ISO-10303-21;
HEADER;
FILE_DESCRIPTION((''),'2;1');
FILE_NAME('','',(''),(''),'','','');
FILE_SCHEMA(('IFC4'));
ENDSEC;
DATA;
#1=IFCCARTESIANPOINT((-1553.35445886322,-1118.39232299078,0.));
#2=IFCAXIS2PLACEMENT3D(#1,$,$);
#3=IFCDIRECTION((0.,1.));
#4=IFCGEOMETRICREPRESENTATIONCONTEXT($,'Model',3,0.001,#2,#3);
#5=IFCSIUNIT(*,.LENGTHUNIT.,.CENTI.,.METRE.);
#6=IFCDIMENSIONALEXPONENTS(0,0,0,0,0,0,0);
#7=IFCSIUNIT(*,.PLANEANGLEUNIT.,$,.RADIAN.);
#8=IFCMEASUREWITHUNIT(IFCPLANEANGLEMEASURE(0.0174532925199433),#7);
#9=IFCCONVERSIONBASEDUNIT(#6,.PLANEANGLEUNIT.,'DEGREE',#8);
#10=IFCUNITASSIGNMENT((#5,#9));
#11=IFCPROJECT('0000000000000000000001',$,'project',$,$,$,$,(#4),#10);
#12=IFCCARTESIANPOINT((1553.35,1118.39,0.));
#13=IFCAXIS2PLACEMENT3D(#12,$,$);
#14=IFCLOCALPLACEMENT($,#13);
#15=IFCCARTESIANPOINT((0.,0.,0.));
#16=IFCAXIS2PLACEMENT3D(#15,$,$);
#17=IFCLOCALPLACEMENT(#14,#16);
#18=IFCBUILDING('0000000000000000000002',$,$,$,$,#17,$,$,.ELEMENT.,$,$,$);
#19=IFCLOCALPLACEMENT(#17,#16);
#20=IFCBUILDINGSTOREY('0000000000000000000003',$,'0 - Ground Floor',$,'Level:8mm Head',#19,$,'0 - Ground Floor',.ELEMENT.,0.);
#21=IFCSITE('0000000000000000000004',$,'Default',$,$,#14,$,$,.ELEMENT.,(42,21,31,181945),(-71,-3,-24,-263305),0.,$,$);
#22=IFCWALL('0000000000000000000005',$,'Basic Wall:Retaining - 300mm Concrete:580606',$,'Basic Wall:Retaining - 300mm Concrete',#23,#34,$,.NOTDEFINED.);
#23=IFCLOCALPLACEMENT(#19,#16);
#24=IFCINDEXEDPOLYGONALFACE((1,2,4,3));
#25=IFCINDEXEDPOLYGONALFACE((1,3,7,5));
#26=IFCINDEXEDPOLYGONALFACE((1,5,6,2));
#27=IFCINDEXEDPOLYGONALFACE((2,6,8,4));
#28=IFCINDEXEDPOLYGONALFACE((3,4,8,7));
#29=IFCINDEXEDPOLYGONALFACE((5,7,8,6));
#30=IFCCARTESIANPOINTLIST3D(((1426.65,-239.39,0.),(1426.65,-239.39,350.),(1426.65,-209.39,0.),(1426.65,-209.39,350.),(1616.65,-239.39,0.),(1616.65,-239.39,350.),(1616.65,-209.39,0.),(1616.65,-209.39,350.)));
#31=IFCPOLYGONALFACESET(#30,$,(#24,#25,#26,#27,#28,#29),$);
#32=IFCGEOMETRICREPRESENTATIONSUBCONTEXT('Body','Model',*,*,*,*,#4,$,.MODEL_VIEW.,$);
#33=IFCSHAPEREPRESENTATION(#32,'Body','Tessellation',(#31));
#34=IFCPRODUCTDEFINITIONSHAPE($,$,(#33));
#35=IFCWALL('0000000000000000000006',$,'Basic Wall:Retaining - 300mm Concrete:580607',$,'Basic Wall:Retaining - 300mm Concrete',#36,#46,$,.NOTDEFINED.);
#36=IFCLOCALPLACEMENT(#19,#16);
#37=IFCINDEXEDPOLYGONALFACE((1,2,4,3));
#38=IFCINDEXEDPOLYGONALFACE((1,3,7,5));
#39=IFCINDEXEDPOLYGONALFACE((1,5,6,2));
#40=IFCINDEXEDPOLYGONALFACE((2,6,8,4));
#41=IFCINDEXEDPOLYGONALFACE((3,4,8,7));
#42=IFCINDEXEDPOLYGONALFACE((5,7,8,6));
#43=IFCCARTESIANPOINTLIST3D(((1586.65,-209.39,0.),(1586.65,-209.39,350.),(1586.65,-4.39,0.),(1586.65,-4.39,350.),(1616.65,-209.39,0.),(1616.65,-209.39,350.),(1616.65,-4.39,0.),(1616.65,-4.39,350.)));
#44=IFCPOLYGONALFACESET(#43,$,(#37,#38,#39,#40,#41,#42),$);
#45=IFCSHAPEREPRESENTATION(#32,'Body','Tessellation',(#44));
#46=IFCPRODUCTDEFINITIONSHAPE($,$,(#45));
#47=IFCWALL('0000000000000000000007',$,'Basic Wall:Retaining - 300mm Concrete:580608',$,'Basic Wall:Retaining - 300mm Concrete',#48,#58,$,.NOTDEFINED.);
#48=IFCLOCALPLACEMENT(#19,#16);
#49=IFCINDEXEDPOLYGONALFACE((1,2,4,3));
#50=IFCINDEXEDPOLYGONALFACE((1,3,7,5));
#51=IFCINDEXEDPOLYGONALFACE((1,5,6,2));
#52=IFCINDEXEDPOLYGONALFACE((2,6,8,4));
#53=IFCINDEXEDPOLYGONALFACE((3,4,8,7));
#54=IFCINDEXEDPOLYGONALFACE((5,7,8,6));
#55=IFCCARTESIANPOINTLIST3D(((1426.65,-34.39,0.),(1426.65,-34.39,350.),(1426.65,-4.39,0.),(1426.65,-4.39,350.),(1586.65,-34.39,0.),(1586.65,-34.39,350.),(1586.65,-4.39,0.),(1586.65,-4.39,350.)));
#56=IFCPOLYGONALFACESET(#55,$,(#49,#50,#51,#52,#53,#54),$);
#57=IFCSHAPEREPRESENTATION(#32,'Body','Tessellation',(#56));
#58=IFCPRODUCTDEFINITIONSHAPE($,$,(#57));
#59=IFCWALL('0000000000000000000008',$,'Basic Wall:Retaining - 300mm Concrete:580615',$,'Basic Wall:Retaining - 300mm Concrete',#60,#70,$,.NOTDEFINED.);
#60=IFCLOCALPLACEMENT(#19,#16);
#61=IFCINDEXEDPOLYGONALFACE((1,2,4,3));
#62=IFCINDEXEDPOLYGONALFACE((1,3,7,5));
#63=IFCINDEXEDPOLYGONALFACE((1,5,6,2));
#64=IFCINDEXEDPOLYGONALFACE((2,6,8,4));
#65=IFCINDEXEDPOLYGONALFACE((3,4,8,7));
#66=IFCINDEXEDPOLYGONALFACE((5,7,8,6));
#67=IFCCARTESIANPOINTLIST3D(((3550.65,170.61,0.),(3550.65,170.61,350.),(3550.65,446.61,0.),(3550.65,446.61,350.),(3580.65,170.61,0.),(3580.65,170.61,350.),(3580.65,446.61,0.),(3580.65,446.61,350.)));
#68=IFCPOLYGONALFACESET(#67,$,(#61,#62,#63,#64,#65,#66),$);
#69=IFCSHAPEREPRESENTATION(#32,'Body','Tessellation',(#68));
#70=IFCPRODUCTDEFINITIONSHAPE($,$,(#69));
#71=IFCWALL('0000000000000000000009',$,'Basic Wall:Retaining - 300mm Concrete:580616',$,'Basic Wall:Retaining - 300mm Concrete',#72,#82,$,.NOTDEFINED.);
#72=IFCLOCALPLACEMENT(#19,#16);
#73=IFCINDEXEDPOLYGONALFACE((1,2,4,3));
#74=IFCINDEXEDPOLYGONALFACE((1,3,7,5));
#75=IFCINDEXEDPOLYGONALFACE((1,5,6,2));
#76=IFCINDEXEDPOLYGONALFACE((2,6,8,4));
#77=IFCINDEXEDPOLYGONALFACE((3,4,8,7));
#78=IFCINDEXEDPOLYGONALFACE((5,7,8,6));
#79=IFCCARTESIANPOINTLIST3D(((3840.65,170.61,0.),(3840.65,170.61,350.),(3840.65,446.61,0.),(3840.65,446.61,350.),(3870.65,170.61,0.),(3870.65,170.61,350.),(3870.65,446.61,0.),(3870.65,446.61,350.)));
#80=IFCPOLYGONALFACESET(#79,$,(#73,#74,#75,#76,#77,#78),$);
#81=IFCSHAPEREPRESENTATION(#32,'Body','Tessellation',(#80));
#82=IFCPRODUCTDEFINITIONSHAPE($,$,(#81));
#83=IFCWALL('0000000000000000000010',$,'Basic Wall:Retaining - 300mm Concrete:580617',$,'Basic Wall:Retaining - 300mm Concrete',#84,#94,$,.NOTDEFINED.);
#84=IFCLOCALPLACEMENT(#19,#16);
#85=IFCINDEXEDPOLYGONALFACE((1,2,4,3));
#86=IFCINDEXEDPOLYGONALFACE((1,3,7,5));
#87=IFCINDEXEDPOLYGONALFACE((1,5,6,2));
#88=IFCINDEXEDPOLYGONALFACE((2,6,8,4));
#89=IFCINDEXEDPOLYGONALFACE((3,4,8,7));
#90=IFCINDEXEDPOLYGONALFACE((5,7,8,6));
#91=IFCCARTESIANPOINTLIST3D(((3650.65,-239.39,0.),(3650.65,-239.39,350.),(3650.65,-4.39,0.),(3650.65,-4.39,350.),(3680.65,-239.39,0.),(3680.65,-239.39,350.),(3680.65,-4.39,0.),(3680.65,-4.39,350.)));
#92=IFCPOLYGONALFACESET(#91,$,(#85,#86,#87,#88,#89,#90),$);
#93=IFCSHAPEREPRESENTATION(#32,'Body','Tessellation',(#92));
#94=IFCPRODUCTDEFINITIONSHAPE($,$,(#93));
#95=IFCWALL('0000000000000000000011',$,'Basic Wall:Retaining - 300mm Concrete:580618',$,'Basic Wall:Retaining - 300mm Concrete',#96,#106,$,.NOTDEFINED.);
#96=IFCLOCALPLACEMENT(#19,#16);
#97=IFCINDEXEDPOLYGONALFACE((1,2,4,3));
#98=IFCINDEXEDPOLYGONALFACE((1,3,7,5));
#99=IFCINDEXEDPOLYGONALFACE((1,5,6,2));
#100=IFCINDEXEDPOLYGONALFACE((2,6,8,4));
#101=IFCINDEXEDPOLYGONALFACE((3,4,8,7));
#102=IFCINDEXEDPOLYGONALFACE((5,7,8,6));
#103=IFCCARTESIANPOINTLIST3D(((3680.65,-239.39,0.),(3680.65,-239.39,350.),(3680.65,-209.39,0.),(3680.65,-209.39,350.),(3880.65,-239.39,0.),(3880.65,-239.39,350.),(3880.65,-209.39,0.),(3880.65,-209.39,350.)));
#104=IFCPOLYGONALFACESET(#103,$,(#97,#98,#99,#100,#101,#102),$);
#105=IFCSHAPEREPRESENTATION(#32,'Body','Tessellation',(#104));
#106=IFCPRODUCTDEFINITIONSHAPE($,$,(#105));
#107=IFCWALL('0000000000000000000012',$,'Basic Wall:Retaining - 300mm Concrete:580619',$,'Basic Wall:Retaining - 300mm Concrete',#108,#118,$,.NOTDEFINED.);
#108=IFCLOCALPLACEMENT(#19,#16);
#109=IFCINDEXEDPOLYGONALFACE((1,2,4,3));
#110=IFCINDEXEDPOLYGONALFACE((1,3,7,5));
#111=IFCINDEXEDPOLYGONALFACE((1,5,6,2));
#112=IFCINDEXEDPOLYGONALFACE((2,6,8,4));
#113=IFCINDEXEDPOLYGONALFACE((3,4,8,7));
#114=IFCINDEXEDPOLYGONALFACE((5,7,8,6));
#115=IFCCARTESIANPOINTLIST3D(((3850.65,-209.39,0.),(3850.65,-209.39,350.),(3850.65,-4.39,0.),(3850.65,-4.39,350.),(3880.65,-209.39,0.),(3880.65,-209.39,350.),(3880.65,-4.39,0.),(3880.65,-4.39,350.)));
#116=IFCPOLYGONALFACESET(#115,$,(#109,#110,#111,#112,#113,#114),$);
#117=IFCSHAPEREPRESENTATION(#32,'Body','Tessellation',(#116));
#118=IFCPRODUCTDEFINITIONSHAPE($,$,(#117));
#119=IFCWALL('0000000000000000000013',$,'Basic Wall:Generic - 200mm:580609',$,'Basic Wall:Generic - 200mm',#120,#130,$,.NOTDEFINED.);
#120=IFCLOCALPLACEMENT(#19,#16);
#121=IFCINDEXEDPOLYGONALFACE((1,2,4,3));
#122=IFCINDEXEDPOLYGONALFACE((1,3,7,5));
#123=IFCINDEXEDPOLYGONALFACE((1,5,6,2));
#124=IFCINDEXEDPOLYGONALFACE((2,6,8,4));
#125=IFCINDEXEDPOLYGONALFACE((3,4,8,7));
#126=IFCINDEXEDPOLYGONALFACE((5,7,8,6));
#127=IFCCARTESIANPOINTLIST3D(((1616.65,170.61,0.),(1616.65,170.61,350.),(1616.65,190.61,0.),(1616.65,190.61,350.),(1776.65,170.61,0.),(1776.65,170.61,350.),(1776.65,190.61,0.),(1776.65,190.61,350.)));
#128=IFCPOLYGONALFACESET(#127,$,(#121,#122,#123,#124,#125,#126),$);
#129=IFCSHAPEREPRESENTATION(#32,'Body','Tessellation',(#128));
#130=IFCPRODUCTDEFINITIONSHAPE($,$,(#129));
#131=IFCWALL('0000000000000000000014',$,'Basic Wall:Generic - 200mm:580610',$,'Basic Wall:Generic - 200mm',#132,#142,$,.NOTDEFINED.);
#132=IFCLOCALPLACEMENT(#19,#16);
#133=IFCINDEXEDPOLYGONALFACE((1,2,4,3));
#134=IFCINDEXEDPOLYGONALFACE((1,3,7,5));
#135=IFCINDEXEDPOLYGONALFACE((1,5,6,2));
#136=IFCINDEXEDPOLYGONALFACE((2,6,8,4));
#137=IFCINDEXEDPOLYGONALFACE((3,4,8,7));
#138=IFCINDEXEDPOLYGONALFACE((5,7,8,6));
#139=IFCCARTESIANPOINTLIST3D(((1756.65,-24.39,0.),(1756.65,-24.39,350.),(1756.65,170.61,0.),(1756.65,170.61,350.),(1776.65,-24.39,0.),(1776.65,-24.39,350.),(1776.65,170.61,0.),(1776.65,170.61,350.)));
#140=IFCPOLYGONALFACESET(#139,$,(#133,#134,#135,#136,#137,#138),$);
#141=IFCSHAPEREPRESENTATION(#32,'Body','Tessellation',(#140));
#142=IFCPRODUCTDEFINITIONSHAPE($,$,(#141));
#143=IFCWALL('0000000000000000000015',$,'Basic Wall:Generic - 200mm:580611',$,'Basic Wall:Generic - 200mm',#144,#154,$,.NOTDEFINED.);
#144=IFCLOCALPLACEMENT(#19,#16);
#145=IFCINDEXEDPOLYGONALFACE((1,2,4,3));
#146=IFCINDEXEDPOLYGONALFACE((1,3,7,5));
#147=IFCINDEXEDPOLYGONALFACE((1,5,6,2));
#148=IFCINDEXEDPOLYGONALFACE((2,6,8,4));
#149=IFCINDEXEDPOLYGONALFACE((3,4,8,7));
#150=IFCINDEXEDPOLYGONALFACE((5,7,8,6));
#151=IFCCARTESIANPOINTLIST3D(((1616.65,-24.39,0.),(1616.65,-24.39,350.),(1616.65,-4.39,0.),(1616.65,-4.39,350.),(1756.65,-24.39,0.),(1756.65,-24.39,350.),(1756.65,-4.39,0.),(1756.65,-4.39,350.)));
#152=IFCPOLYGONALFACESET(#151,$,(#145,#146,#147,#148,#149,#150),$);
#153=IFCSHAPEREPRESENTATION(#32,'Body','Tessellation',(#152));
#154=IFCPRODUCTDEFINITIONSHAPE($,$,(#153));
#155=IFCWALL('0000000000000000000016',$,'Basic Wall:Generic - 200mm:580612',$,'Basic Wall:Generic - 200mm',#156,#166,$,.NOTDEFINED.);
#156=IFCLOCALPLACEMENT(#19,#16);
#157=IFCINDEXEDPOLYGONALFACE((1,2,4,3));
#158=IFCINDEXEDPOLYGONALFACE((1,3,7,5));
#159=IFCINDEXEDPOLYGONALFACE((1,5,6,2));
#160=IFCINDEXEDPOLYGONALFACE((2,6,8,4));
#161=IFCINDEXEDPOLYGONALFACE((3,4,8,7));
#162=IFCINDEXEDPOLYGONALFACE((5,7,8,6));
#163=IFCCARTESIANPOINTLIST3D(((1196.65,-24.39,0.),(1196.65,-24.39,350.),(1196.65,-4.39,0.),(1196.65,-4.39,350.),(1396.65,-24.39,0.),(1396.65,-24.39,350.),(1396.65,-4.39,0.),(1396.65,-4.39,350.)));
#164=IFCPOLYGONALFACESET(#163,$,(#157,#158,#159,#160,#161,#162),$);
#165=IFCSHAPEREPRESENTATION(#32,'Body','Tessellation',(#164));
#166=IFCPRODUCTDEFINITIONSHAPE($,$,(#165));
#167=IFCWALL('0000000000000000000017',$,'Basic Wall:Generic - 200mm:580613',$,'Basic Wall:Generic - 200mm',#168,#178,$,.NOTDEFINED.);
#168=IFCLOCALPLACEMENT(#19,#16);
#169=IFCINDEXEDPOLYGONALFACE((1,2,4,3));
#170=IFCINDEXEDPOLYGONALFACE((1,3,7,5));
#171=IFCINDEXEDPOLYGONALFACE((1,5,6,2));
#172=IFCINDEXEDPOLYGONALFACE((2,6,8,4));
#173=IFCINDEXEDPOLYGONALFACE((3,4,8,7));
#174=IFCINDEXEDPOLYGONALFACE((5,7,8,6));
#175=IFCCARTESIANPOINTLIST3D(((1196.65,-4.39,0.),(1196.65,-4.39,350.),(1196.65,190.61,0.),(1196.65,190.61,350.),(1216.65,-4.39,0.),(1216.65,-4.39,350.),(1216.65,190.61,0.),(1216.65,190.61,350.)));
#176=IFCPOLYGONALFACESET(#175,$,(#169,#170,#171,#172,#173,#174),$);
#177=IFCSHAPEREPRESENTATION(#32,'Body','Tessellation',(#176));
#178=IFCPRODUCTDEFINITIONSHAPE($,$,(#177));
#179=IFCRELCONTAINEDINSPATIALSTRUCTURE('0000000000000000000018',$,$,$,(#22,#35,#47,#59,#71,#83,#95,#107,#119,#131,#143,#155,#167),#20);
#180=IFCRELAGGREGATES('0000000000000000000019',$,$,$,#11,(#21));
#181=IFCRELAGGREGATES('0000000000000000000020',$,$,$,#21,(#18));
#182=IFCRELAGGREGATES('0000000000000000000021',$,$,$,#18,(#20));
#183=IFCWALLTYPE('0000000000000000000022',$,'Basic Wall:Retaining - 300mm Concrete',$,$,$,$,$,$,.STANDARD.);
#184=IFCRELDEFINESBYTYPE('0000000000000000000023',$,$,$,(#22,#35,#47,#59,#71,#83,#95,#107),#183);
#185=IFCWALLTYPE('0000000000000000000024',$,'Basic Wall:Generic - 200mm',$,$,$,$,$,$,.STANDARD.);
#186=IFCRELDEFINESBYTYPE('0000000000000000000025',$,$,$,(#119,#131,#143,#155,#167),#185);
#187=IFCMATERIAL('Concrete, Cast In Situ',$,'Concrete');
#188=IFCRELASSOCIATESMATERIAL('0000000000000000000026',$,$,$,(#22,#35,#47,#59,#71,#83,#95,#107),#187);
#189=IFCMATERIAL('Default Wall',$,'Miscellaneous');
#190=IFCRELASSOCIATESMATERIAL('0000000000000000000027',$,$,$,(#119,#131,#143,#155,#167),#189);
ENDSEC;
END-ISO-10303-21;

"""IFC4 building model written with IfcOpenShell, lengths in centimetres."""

from ifc_helpers import new_model, entity, si_unit, converted_unit, direction, frame, origin, place, context, subcontext, project, spatial, indexed_curve, outline, extrude, material, type_object, element, save


model = new_model("IFC4")

# Units and contexts
model_context = context("Model", 3, precision=0.001, world=frame((-1553.35445886322, -1118.39232299078, 0.0)), true_north=direction((0.0, 1.0)))
body_context = subcontext(model_context, "Body", "Model", "MODEL_VIEW")
ifc_project = project(units=[si_unit("LENGTHUNIT", "METRE", prefix="CENTI"), converted_unit("PLANEANGLEUNIT", "DEGREE", entity("IfcPlaneAngleMeasure", 0.0174532925199433), si_unit("PLANEANGLEUNIT", "RADIAN"), dimensions=[0, 0, 0, 0, 0, 0, 0])], contexts=[model_context])

# Site, building, storey
site_placement = place(None, frame((1553.35, 1118.39, 0.0)))
site = spatial("IfcSite", under=ifc_project, at=site_placement, Name="Default", CompositionType="ELEMENT", RefLatitude=(42, 21, 31, 181945), RefLongitude=(-71, -3, -24, -263305), RefElevation=0.0)
building_placement = place(site_placement, origin())
building = spatial("IfcBuilding", under=site, at=building_placement, CompositionType="ELEMENT")
storey_placement = place(building_placement, origin())
storey = spatial("IfcBuildingStorey", under=building, at=storey_placement, Name="0 - Ground Floor", ObjectType="Level:8mm Head", LongName="0 - Ground Floor", CompositionType="ELEMENT", Elevation=0.0)

# Walls
ifc_material_1 = material(Name="Concrete, Cast In Situ", Category="Concrete")
wall_type_1 = type_object("IfcWallType", Name="Basic Wall:Retaining - 300mm Concrete", PredefinedType="STANDARD")
wall_1_placement = place(storey_placement, frame((1426.65, -224.39, 0.0)))
element("IfcWall", 1, at=wall_1_placement, inside=storey, type_object=wall_type_1, material=ifc_material_1, Name="Basic Wall:Retaining - 300mm Concrete:580606", ObjectType="Basic Wall:Retaining - 300mm Concrete", PredefinedType="NOTDEFINED", context=body_context, shape_type="SweptSolid", body=[
    extrude(outline(indexed_curve([(190.0, 15.0), (0.0, 15.0), (0.0, -15.0), (190.0, -15.0), (190.0, 15.0)], self_intersect=False)), origin(), (0.0, 0.0, 1.0), 350.0),
])
wall_2_placement = place(storey_placement, frame((1601.65, -209.39, 0.0), z_axis=(0.0, 0.0, 1.0), x_axis=(0.0, 1.0, 0.0)))
element("IfcWall", 2, at=wall_2_placement, inside=storey, type_object=wall_type_1, material=ifc_material_1, Name="Basic Wall:Retaining - 300mm Concrete:580607", ObjectType="Basic Wall:Retaining - 300mm Concrete", PredefinedType="NOTDEFINED", context=body_context, shape_type="SweptSolid", body=[
    extrude(outline(indexed_curve([(205.0, 15.0), (0.0, 15.0), (0.0, -15.0), (205.0, -15.0), (205.0, 15.0)], self_intersect=False)), origin(), (0.0, 0.0, 1.0), 350.0),
])
wall_3_placement = place(storey_placement, frame((1586.65, -19.39, 0.0), z_axis=(0.0, 0.0, 1.0), x_axis=(-1.0, 0.0, 0.0)))
element("IfcWall", 3, at=wall_3_placement, inside=storey, type_object=wall_type_1, material=ifc_material_1, Name="Basic Wall:Retaining - 300mm Concrete:580608", ObjectType="Basic Wall:Retaining - 300mm Concrete", PredefinedType="NOTDEFINED", context=body_context, shape_type="SweptSolid", body=[
    extrude(outline(indexed_curve([(160.0, 15.0), (0.0, 15.0), (0.0, -15.0), (160.0, -15.0), (160.0, 15.0)], self_intersect=False)), origin(), (0.0, 0.0, 1.0), 350.0),
])
wall_4_placement = place(storey_placement, frame((3565.65, 446.61, 0.0), z_axis=(0.0, 0.0, 1.0), x_axis=(0.0, -1.0, 0.0)))
element("IfcWall", 4, at=wall_4_placement, inside=storey, type_object=wall_type_1, material=ifc_material_1, Name="Basic Wall:Retaining - 300mm Concrete:580615", ObjectType="Basic Wall:Retaining - 300mm Concrete", PredefinedType="NOTDEFINED", context=body_context, shape_type="SweptSolid", body=[
    extrude(outline(indexed_curve([(276.0, 15.0), (0.0, 15.0), (0.0, -15.0), (276.0, -15.0), (276.0, 15.0)], self_intersect=False)), origin(), (0.0, 0.0, 1.0), 350.0),
])
wall_5_placement = place(storey_placement, frame((3855.65, 446.61, 0.0), z_axis=(0.0, 0.0, 1.0), x_axis=(0.0, -1.0, 0.0)))
element("IfcWall", 5, at=wall_5_placement, inside=storey, type_object=wall_type_1, material=ifc_material_1, Name="Basic Wall:Retaining - 300mm Concrete:580616", ObjectType="Basic Wall:Retaining - 300mm Concrete", PredefinedType="NOTDEFINED", context=body_context, shape_type="SweptSolid", body=[
    extrude(outline(indexed_curve([(276.0, 15.0), (0.0, 15.0), (0.0, -15.0), (276.0, -15.0), (276.0, 15.0)], self_intersect=False)), origin(), (0.0, 0.0, 1.0), 350.0),
])
wall_6_placement = place(storey_placement, frame((3665.65, -4.39, 0.0), z_axis=(0.0, 0.0, 1.0), x_axis=(0.0, -1.0, 0.0)))
element("IfcWall", 6, at=wall_6_placement, inside=storey, type_object=wall_type_1, material=ifc_material_1, Name="Basic Wall:Retaining - 300mm Concrete:580617", ObjectType="Basic Wall:Retaining - 300mm Concrete", PredefinedType="NOTDEFINED", context=body_context, shape_type="SweptSolid", body=[
    extrude(outline(indexed_curve([(235.0, 15.0), (0.0, 15.0), (0.0, -15.0), (235.0, -15.0), (235.0, 15.0)], self_intersect=False)), origin(), (0.0, 0.0, 1.0), 350.0),
])
wall_7_placement = place(storey_placement, frame((3680.65, -224.39, 0.0)))
element("IfcWall", 7, at=wall_7_placement, inside=storey, type_object=wall_type_1, material=ifc_material_1, Name="Basic Wall:Retaining - 300mm Concrete:580618", ObjectType="Basic Wall:Retaining - 300mm Concrete", PredefinedType="NOTDEFINED", context=body_context, shape_type="SweptSolid", body=[
    extrude(outline(indexed_curve([(200.0, 15.0), (0.0, 15.0), (0.0, -15.0), (200.0, -15.0), (200.0, 15.0)], self_intersect=False)), origin(), (0.0, 0.0, 1.0), 350.0),
])
wall_8_placement = place(storey_placement, frame((3865.65, -209.39, 0.0), z_axis=(0.0, 0.0, 1.0), x_axis=(0.0, 1.0, 0.0)))
element("IfcWall", 8, at=wall_8_placement, inside=storey, type_object=wall_type_1, material=ifc_material_1, Name="Basic Wall:Retaining - 300mm Concrete:580619", ObjectType="Basic Wall:Retaining - 300mm Concrete", PredefinedType="NOTDEFINED", context=body_context, shape_type="SweptSolid", body=[
    extrude(outline(indexed_curve([(205.0, 15.0), (0.0, 15.0), (0.0, -15.0), (205.0, -15.0), (205.0, 15.0)], self_intersect=False)), origin(), (0.0, 0.0, 1.0), 350.0),
])
ifc_material_2 = material(Name="Default Wall", Category="Miscellaneous")
wall_type_2 = type_object("IfcWallType", Name="Basic Wall:Generic - 200mm", PredefinedType="STANDARD")
wall_9_placement = place(storey_placement, frame((1616.65, 180.61, 0.0)))
element("IfcWall", 9, at=wall_9_placement, inside=storey, type_object=wall_type_2, material=ifc_material_2, Name="Basic Wall:Generic - 200mm:580609", ObjectType="Basic Wall:Generic - 200mm", PredefinedType="NOTDEFINED", context=body_context, shape_type="SweptSolid", body=[
    extrude(outline(indexed_curve([(160.0, 10.0), (0.0, 10.0), (0.0, -10.0), (160.0, -10.0), (160.0, 10.0)], self_intersect=False)), origin(), (0.0, 0.0, 1.0), 350.0),
])
wall_10_placement = place(storey_placement, frame((1766.65, 170.61, 0.0), z_axis=(0.0, 0.0, 1.0), x_axis=(0.0, -1.0, 0.0)))
element("IfcWall", 10, at=wall_10_placement, inside=storey, type_object=wall_type_2, material=ifc_material_2, Name="Basic Wall:Generic - 200mm:580610", ObjectType="Basic Wall:Generic - 200mm", PredefinedType="NOTDEFINED", context=body_context, shape_type="SweptSolid", body=[
    extrude(outline(indexed_curve([(195.0, 10.0), (0.0, 10.0), (0.0, -10.0), (195.0, -10.0), (195.0, 10.0)], self_intersect=False)), origin(), (0.0, 0.0, 1.0), 350.0),
])
wall_11_placement = place(storey_placement, frame((1616.65, -14.39, 0.0)))
element("IfcWall", 11, at=wall_11_placement, inside=storey, type_object=wall_type_2, material=ifc_material_2, Name="Basic Wall:Generic - 200mm:580611", ObjectType="Basic Wall:Generic - 200mm", PredefinedType="NOTDEFINED", context=body_context, shape_type="SweptSolid", body=[
    extrude(outline(indexed_curve([(140.0, 10.0), (0.0, 10.0), (0.0, -10.0), (140.0, -10.0), (140.0, 10.0)], self_intersect=False)), origin(), (0.0, 0.0, 1.0), 350.0),
])
wall_12_placement = place(storey_placement, frame((1396.65, -14.39, 0.0), z_axis=(0.0, 0.0, 1.0), x_axis=(-1.0, 0.0, 0.0)))
element("IfcWall", 12, at=wall_12_placement, inside=storey, type_object=wall_type_2, material=ifc_material_2, Name="Basic Wall:Generic - 200mm:580612", ObjectType="Basic Wall:Generic - 200mm", PredefinedType="NOTDEFINED", context=body_context, shape_type="SweptSolid", body=[
    extrude(outline(indexed_curve([(200.0, 10.0), (0.0, 10.0), (0.0, -10.0), (200.0, -10.0), (200.0, 10.0)], self_intersect=False)), origin(), (0.0, 0.0, 1.0), 350.0),
])
wall_13_placement = place(storey_placement, frame((1206.65, -4.39, 0.0), z_axis=(0.0, 0.0, 1.0), x_axis=(0.0, 1.0, 0.0)))
element("IfcWall", 13, at=wall_13_placement, inside=storey, type_object=wall_type_2, material=ifc_material_2, Name="Basic Wall:Generic - 200mm:580613", ObjectType="Basic Wall:Generic - 200mm", PredefinedType="NOTDEFINED", context=body_context, shape_type="SweptSolid", body=[
    extrude(outline(indexed_curve([(195.0, 10.0), (0.0, 10.0), (0.0, -10.0), (195.0, -10.0), (195.0, 10.0)], self_intersect=False)), origin(), (0.0, 0.0, 1.0), 350.0),
])

save(model, "model.ifc")
